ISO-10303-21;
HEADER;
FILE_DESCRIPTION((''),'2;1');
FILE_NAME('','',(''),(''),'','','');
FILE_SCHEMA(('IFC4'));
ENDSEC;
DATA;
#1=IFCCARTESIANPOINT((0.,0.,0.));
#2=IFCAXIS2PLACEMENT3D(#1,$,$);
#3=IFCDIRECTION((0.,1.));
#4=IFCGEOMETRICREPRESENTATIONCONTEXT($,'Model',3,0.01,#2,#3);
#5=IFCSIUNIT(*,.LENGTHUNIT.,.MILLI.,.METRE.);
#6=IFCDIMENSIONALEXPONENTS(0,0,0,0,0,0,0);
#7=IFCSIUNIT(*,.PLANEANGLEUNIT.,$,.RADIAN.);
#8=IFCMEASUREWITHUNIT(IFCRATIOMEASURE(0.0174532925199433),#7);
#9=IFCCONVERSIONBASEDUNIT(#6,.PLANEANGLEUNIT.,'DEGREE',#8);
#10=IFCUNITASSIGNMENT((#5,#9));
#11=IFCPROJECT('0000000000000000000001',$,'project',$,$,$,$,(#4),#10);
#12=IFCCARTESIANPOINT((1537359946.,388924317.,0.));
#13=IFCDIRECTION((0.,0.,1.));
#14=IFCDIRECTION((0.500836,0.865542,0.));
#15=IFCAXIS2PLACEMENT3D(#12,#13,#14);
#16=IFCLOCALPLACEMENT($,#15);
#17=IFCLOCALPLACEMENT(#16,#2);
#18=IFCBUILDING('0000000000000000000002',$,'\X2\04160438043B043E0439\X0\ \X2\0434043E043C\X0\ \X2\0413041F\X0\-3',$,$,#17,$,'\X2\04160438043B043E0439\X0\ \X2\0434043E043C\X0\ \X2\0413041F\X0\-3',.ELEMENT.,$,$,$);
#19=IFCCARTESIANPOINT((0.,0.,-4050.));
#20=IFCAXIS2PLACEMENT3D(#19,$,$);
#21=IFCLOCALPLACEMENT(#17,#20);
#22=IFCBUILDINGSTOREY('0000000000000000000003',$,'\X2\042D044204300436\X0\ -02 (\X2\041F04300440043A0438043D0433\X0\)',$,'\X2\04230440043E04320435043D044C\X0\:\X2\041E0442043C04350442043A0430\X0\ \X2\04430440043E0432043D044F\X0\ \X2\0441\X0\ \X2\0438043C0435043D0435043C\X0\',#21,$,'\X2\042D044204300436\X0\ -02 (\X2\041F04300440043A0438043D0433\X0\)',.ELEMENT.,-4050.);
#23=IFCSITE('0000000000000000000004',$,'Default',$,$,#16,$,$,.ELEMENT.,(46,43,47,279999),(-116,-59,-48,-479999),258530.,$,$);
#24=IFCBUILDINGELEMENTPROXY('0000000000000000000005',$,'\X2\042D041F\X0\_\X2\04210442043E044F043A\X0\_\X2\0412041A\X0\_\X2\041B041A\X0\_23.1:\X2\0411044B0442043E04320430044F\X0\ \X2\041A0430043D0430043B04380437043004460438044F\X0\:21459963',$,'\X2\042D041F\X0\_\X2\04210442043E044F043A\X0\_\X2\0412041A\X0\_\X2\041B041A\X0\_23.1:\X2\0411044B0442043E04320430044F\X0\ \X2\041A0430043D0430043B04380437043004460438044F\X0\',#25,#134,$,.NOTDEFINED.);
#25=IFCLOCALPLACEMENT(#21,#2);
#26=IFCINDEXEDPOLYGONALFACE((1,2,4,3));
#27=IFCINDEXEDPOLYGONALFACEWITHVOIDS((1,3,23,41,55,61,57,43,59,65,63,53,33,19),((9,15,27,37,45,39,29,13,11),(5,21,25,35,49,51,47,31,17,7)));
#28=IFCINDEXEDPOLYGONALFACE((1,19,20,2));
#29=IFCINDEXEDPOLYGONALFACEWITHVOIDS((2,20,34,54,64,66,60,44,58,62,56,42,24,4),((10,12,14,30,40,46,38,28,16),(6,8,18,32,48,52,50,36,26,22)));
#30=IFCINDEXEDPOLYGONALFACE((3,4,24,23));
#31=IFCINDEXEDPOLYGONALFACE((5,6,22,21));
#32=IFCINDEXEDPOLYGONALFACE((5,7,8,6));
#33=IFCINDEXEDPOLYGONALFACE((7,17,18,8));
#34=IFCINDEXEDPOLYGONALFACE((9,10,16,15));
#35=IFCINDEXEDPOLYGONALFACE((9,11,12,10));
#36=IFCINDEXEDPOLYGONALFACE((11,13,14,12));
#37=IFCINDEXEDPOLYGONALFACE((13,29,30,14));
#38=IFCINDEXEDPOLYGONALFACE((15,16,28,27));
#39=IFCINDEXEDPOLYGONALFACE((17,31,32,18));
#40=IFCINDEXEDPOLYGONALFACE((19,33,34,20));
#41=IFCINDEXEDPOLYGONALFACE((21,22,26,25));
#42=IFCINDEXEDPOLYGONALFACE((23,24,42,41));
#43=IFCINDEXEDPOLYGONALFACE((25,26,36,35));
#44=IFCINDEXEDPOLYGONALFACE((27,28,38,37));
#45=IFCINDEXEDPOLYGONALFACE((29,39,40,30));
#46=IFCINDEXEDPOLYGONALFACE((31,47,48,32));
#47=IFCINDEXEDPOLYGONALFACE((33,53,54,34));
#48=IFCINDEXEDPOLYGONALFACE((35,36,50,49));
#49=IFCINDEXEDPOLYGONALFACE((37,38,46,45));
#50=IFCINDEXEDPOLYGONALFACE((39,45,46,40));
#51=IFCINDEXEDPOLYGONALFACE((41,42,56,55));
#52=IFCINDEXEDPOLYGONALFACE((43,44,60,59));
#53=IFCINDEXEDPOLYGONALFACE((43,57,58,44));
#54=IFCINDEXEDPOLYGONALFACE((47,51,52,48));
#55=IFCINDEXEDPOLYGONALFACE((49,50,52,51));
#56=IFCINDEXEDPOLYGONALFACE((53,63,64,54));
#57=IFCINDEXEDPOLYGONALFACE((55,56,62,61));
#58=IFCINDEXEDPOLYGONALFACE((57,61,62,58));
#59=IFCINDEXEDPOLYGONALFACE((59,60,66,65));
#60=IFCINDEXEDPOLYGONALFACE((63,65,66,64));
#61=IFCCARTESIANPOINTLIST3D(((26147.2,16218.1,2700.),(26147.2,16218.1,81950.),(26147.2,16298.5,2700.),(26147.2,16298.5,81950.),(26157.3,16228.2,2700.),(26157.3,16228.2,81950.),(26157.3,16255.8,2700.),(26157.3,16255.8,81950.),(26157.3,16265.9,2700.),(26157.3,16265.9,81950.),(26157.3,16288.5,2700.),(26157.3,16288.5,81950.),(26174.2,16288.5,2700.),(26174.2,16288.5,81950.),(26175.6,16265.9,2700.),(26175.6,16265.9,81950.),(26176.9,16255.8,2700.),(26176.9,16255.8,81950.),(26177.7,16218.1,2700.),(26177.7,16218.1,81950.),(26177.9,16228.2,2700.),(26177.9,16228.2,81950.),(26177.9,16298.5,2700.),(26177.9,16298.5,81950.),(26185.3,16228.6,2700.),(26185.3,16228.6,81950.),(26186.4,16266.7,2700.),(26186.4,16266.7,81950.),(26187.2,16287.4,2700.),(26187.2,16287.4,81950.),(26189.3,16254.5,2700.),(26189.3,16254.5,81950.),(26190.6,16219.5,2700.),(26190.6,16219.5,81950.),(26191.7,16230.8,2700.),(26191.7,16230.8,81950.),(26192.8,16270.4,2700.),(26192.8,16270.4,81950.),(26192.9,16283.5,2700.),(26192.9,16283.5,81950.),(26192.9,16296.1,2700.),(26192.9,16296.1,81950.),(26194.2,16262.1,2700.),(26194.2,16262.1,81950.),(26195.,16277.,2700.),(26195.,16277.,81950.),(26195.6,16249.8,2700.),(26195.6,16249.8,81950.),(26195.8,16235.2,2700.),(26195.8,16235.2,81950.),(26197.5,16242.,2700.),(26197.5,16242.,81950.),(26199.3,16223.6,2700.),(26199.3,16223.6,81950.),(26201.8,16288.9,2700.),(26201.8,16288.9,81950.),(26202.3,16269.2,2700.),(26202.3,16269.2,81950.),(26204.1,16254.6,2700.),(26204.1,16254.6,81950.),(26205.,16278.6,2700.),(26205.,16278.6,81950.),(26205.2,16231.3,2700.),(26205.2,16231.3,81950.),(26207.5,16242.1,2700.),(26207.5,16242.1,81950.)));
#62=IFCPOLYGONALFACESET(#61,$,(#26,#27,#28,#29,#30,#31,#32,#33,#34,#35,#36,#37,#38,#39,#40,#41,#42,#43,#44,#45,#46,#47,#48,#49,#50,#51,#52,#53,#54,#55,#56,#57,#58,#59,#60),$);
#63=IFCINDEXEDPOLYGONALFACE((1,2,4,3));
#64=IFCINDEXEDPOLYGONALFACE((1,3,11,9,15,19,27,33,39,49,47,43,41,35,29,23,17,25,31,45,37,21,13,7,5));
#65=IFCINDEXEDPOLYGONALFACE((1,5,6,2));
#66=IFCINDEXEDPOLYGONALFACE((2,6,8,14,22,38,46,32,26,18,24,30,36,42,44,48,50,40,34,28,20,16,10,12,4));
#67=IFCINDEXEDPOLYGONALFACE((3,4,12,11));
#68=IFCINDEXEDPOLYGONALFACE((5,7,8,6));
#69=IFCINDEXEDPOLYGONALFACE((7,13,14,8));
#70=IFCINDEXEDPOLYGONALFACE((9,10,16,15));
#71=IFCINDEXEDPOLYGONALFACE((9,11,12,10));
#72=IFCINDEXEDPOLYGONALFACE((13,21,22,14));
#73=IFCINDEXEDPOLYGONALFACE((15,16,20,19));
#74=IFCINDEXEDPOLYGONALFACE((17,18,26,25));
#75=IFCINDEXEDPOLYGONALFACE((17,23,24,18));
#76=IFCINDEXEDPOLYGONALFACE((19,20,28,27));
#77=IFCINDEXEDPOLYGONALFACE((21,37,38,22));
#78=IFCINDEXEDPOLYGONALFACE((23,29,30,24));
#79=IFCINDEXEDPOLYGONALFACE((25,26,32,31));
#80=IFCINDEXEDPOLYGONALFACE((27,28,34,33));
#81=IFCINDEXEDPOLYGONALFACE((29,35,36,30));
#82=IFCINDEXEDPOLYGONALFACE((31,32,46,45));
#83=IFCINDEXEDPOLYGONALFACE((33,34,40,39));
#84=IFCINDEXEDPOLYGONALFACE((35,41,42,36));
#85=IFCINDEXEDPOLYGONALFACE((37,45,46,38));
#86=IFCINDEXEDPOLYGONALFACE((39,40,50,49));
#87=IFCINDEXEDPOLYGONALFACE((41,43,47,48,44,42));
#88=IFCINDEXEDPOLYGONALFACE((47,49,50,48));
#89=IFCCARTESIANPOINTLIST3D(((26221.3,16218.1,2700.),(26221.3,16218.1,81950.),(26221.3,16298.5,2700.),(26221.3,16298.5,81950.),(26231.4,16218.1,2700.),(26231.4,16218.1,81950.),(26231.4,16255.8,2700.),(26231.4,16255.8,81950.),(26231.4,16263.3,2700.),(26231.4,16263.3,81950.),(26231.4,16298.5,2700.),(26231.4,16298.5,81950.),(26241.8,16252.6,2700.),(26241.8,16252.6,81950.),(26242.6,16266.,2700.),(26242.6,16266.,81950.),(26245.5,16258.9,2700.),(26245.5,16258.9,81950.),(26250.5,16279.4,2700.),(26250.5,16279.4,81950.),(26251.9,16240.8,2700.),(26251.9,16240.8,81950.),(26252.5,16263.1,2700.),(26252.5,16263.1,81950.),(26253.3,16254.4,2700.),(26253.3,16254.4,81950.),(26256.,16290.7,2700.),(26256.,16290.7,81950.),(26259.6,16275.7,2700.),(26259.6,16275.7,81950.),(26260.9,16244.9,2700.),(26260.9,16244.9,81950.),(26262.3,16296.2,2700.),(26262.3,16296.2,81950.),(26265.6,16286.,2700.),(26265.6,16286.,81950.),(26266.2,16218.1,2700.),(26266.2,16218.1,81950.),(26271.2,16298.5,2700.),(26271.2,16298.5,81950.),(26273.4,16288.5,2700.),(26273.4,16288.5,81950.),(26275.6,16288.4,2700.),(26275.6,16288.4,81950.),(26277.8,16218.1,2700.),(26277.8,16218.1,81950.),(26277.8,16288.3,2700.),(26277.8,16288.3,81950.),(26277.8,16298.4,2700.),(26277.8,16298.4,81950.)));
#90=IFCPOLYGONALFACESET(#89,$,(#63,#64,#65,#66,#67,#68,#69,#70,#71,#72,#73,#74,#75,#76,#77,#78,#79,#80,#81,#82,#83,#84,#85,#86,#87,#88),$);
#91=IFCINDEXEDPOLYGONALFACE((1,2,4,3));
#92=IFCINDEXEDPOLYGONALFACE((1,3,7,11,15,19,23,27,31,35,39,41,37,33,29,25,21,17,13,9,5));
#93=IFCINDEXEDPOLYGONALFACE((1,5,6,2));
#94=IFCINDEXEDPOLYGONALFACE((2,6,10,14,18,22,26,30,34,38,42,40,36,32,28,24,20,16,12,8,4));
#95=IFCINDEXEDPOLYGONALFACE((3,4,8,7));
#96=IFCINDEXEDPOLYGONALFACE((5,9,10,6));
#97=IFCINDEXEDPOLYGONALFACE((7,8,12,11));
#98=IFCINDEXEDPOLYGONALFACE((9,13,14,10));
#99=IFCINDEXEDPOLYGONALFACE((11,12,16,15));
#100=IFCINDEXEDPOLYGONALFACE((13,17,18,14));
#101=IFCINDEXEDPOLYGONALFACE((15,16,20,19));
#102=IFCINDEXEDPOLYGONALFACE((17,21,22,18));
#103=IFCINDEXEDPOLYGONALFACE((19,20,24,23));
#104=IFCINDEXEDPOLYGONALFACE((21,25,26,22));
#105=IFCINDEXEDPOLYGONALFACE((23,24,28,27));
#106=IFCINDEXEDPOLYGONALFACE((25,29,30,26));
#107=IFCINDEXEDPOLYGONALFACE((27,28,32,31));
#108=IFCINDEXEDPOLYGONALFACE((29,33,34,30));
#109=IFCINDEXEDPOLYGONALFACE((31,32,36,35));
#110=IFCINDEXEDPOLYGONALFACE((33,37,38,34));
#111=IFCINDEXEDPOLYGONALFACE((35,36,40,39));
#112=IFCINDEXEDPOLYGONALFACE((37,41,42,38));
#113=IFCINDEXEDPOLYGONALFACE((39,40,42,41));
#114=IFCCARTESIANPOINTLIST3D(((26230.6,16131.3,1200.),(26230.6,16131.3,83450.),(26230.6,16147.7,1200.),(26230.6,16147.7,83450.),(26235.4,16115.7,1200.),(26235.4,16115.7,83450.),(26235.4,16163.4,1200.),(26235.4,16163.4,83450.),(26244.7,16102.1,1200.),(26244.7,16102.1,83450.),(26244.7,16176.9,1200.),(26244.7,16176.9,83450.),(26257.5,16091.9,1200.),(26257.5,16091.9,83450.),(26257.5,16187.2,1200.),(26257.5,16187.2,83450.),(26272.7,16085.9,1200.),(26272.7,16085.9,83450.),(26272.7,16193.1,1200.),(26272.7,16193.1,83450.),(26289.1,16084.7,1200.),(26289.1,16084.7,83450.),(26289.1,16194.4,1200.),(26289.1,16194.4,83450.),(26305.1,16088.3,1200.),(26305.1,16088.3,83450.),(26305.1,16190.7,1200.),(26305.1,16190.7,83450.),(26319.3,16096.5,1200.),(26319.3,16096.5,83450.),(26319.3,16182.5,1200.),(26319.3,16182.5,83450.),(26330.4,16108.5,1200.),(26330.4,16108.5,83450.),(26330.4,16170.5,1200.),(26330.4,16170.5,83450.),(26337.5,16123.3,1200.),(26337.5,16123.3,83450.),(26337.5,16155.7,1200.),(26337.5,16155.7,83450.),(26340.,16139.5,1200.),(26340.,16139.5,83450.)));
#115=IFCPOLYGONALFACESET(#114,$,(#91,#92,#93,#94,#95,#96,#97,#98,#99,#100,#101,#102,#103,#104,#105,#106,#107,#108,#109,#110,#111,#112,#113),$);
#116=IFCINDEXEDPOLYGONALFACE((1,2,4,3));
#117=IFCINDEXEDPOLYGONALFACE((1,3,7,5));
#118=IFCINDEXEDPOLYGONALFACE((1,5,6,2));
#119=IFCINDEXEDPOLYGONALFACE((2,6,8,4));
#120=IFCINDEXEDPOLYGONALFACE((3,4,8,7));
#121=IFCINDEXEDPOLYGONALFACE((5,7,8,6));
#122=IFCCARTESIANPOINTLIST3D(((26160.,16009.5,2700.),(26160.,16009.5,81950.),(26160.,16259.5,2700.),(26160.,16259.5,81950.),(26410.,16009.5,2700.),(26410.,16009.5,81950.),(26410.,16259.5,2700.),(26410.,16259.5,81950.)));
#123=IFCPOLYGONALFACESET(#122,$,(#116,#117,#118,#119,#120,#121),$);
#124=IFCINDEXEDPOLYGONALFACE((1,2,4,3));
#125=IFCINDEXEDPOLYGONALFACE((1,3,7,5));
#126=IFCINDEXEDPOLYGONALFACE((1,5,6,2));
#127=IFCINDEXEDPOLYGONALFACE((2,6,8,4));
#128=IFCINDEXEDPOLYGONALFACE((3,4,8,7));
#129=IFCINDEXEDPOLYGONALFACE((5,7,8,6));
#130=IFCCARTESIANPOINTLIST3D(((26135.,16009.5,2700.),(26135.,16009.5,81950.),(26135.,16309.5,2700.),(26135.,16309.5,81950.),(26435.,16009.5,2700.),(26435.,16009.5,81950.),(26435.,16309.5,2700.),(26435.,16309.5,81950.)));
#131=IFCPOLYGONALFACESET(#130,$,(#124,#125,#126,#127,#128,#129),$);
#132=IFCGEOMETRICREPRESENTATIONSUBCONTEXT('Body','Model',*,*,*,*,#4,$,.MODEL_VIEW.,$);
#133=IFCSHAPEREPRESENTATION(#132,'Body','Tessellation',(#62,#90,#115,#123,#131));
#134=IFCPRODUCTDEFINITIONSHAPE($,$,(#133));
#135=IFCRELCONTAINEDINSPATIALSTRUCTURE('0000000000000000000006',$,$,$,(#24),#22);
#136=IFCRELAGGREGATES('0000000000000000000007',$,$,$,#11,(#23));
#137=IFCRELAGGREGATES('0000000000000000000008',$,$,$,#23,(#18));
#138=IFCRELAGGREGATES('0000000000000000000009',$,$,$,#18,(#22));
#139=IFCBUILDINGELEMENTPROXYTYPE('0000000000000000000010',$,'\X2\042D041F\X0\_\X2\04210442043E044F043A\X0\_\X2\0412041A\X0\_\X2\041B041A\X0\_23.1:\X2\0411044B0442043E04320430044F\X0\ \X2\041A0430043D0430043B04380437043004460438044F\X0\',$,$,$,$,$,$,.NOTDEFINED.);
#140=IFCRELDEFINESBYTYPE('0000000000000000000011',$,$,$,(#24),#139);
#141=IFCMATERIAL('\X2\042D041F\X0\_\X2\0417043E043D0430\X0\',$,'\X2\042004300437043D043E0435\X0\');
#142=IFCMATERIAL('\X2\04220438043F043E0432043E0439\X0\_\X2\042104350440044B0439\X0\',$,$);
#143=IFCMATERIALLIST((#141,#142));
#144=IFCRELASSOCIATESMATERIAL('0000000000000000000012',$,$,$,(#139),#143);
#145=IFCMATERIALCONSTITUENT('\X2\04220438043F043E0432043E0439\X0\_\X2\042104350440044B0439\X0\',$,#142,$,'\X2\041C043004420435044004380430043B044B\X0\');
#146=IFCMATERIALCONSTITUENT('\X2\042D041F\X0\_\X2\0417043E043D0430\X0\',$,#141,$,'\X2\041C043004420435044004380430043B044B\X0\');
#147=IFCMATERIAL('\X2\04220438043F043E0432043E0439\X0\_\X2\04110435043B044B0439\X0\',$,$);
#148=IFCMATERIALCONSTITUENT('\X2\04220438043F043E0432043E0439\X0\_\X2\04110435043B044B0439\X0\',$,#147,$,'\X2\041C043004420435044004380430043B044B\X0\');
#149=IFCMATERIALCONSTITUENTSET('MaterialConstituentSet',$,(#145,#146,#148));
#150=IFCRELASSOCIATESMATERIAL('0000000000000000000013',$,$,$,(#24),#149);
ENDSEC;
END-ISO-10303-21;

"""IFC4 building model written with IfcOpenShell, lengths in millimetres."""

from ifc_helpers import new_model, entity, si_unit, converted_unit, direction, frame, frame_2d, origin, place, context, subcontext, project, spatial, polyline, rectangle, circle, outline, extrude, source, transform, mapped, material, material_list, constituent, constituent_set, type_object, type_shapes, element, save


model = new_model("IFC4")

# Units and contexts
model_context = context("Model", 3, precision=0.01, world=origin(), true_north=direction((0.0, 1.0)))
body_context = subcontext(model_context, "Body", "Model", "MODEL_VIEW")
ifc_project = project(units=[si_unit("LENGTHUNIT", "METRE", prefix="MILLI"), converted_unit("PLANEANGLEUNIT", "DEGREE", entity("IfcRatioMeasure", 0.0174532925199433), si_unit("PLANEANGLEUNIT", "RADIAN"), dimensions=[0, 0, 0, 0, 0, 0, 0])], contexts=[model_context])

# Site, building, storey
site_placement = place(None, frame((1537359946.0, 388924317.0, 0.0), z_axis=(0.0, 0.0, 1.0), x_axis=(0.500836, 0.865542, 0.0)))
site = spatial("IfcSite", under=ifc_project, at=site_placement, Name="Default", CompositionType="ELEMENT", RefLatitude=(46, 43, 47, 279999), RefLongitude=(-116, -59, -48, -479999), RefElevation=258530.0)
building_placement = place(site_placement, origin())
building = spatial("IfcBuilding", under=site, at=building_placement, Name="Жилой дом ГП-3", LongName="Жилой дом ГП-3", CompositionType="ELEMENT")
storey_placement = place(building_placement, frame((0.0, 0.0, -4050.0)))
storey = spatial("IfcBuildingStorey", under=building, at=storey_placement, Name="Этаж -02 (Паркинг)", ObjectType="Уровень:Отметка уровня с именем", LongName="Этаж -02 (Паркинг)", CompositionType="ELEMENT", Elevation=-4050.0)

# Building element proxy
ifc_material_1 = material(Name="ЭП_Зона", Category="Разное")
ifc_material_2 = material(Name="Типовой_Белый")
ifc_material_3 = material(Name="Типовой_Серый")
ifc_material_list_1 = material_list([ifc_material_1, ifc_material_3])
building_element_proxy_type_1 = type_object("IfcBuildingElementProxyType", Name="ЭП_Стояк_ВК_ЛК_23.1:Бытовая Канализация", PredefinedType="NOTDEFINED", material=ifc_material_list_1)
shared_shape_1 = source(origin(), body_context, "Body", "SweptSolid", [
    extrude(outline(polyline([(-42.2, -39.0), (-11.8, -39.0), (1.1, -37.6), (9.8, -33.5), (15.7, -25.8), (18.0, -15.0), (14.6, -2.5), (4.7, 5.0), (12.8, 12.1), (15.5, 21.5), (12.3, 31.8), (3.4, 39.0), (-11.6, 41.4), (-42.2, 41.4), (-42.2, -39.0)]), holes=[polyline([(-32.2, 8.8), (-32.2, 31.4), (-15.2, 31.4), (-2.3, 30.3), (3.5, 26.4), (5.5, 19.9), (3.3, 13.3), (-3.1, 9.6), (-13.9, 8.8), (-32.2, 8.8)]), polyline([(-32.2, -28.9), (-32.2, -1.3), (-12.6, -1.3), (-0.2, -2.6), (6.1, -7.3), (8.0, -15.1), (6.3, -21.9), (2.2, -26.3), (-4.1, -28.5), (-11.6, -28.9), (-32.2, -28.9)])]), frame((54.5, -52.4, -1350.0)), (0.0, 0.0, 1.0), 79250.0),
    extrude(outline(polyline([(-32.1, -31.9), (48.3, -31.9), (48.3, -21.8), (10.6, -21.8), (13.8, -11.4), (25.6, -1.3), (48.3, 13.0), (48.3, 24.6), (21.4, 7.7), (12.0, 0.1), (7.4, -7.7), (3.3, -0.7), (-9.3, 6.4), (-19.7, 12.3), (-22.1, 20.2), (-22.0, 22.4), (-22.0, 24.6), (-32.0, 24.6), (-32.1, 18.0), (-29.9, 9.0), (-24.3, 2.8), (-13.1, -2.8), (0.4, -10.6), (3.0, -21.8), (-32.1, -21.8), (-32.1, -31.9)])), frame((118.2, -43.1, -1350.0), z_axis=(0.0, 0.0, 1.0), x_axis=(0.0, -1.0, 0.0)), (0.0, 0.0, 1.0), 79250.0),
    extrude(circle(Radius=55.0, at=frame_2d((0.0, 0.0), x_axis=(1.0, 0.0))), frame((150.0, -170.0, -2850.0)), (0.0, 0.0, 1.0), 82250.0),
    extrude(rectangle(XDim=250.0, YDim=250.0, at=frame_2d((0.0, 0.0), x_axis=(1.0, 0.0))), frame((150.0, -175.0, -1350.0)), (0.0, 0.0, 1.0), 79250.0),
    extrude(rectangle(XDim=300.0, YDim=300.0, at=frame_2d((0.0, 0.0), x_axis=(1.0, 0.0))), frame((150.0, -150.0, -1350.0)), (0.0, 0.0, 1.0), 79250.0),
])
type_shapes(building_element_proxy_type_1, [shared_shape_1])
ifc_constituent_1 = constituent(ifc_material_3, Name="Типовой_Серый", Category="Материалы")
ifc_constituent_2 = constituent(ifc_material_1, Name="ЭП_Зона", Category="Материалы")
ifc_constituent_3 = constituent(ifc_material_2, Name="Типовой_Белый", Category="Материалы")
ifc_constituent_set_1 = constituent_set(constituents=[ifc_constituent_1, ifc_constituent_2, ifc_constituent_3], Name="MaterialConstituentSet")
proxy_1_placement = place(storey_placement, frame((26135.0, 16309.5, 4050.0)))
element("IfcBuildingElementProxy", 1, at=proxy_1_placement, inside=storey, type_object=building_element_proxy_type_1, material=ifc_constituent_set_1, Name="ЭП_Стояк_ВК_ЛК_23.1:Бытовая Канализация:21459963", ObjectType="ЭП_Стояк_ВК_ЛК_23.1:Бытовая Канализация", PredefinedType="NOTDEFINED", context=body_context, shape_type="MappedRepresentation", body=[
    mapped(shared_shape_1, transform((0.0, 0.0, 0.0), scale=1.0)),
])

save(model, "model.ifc")
